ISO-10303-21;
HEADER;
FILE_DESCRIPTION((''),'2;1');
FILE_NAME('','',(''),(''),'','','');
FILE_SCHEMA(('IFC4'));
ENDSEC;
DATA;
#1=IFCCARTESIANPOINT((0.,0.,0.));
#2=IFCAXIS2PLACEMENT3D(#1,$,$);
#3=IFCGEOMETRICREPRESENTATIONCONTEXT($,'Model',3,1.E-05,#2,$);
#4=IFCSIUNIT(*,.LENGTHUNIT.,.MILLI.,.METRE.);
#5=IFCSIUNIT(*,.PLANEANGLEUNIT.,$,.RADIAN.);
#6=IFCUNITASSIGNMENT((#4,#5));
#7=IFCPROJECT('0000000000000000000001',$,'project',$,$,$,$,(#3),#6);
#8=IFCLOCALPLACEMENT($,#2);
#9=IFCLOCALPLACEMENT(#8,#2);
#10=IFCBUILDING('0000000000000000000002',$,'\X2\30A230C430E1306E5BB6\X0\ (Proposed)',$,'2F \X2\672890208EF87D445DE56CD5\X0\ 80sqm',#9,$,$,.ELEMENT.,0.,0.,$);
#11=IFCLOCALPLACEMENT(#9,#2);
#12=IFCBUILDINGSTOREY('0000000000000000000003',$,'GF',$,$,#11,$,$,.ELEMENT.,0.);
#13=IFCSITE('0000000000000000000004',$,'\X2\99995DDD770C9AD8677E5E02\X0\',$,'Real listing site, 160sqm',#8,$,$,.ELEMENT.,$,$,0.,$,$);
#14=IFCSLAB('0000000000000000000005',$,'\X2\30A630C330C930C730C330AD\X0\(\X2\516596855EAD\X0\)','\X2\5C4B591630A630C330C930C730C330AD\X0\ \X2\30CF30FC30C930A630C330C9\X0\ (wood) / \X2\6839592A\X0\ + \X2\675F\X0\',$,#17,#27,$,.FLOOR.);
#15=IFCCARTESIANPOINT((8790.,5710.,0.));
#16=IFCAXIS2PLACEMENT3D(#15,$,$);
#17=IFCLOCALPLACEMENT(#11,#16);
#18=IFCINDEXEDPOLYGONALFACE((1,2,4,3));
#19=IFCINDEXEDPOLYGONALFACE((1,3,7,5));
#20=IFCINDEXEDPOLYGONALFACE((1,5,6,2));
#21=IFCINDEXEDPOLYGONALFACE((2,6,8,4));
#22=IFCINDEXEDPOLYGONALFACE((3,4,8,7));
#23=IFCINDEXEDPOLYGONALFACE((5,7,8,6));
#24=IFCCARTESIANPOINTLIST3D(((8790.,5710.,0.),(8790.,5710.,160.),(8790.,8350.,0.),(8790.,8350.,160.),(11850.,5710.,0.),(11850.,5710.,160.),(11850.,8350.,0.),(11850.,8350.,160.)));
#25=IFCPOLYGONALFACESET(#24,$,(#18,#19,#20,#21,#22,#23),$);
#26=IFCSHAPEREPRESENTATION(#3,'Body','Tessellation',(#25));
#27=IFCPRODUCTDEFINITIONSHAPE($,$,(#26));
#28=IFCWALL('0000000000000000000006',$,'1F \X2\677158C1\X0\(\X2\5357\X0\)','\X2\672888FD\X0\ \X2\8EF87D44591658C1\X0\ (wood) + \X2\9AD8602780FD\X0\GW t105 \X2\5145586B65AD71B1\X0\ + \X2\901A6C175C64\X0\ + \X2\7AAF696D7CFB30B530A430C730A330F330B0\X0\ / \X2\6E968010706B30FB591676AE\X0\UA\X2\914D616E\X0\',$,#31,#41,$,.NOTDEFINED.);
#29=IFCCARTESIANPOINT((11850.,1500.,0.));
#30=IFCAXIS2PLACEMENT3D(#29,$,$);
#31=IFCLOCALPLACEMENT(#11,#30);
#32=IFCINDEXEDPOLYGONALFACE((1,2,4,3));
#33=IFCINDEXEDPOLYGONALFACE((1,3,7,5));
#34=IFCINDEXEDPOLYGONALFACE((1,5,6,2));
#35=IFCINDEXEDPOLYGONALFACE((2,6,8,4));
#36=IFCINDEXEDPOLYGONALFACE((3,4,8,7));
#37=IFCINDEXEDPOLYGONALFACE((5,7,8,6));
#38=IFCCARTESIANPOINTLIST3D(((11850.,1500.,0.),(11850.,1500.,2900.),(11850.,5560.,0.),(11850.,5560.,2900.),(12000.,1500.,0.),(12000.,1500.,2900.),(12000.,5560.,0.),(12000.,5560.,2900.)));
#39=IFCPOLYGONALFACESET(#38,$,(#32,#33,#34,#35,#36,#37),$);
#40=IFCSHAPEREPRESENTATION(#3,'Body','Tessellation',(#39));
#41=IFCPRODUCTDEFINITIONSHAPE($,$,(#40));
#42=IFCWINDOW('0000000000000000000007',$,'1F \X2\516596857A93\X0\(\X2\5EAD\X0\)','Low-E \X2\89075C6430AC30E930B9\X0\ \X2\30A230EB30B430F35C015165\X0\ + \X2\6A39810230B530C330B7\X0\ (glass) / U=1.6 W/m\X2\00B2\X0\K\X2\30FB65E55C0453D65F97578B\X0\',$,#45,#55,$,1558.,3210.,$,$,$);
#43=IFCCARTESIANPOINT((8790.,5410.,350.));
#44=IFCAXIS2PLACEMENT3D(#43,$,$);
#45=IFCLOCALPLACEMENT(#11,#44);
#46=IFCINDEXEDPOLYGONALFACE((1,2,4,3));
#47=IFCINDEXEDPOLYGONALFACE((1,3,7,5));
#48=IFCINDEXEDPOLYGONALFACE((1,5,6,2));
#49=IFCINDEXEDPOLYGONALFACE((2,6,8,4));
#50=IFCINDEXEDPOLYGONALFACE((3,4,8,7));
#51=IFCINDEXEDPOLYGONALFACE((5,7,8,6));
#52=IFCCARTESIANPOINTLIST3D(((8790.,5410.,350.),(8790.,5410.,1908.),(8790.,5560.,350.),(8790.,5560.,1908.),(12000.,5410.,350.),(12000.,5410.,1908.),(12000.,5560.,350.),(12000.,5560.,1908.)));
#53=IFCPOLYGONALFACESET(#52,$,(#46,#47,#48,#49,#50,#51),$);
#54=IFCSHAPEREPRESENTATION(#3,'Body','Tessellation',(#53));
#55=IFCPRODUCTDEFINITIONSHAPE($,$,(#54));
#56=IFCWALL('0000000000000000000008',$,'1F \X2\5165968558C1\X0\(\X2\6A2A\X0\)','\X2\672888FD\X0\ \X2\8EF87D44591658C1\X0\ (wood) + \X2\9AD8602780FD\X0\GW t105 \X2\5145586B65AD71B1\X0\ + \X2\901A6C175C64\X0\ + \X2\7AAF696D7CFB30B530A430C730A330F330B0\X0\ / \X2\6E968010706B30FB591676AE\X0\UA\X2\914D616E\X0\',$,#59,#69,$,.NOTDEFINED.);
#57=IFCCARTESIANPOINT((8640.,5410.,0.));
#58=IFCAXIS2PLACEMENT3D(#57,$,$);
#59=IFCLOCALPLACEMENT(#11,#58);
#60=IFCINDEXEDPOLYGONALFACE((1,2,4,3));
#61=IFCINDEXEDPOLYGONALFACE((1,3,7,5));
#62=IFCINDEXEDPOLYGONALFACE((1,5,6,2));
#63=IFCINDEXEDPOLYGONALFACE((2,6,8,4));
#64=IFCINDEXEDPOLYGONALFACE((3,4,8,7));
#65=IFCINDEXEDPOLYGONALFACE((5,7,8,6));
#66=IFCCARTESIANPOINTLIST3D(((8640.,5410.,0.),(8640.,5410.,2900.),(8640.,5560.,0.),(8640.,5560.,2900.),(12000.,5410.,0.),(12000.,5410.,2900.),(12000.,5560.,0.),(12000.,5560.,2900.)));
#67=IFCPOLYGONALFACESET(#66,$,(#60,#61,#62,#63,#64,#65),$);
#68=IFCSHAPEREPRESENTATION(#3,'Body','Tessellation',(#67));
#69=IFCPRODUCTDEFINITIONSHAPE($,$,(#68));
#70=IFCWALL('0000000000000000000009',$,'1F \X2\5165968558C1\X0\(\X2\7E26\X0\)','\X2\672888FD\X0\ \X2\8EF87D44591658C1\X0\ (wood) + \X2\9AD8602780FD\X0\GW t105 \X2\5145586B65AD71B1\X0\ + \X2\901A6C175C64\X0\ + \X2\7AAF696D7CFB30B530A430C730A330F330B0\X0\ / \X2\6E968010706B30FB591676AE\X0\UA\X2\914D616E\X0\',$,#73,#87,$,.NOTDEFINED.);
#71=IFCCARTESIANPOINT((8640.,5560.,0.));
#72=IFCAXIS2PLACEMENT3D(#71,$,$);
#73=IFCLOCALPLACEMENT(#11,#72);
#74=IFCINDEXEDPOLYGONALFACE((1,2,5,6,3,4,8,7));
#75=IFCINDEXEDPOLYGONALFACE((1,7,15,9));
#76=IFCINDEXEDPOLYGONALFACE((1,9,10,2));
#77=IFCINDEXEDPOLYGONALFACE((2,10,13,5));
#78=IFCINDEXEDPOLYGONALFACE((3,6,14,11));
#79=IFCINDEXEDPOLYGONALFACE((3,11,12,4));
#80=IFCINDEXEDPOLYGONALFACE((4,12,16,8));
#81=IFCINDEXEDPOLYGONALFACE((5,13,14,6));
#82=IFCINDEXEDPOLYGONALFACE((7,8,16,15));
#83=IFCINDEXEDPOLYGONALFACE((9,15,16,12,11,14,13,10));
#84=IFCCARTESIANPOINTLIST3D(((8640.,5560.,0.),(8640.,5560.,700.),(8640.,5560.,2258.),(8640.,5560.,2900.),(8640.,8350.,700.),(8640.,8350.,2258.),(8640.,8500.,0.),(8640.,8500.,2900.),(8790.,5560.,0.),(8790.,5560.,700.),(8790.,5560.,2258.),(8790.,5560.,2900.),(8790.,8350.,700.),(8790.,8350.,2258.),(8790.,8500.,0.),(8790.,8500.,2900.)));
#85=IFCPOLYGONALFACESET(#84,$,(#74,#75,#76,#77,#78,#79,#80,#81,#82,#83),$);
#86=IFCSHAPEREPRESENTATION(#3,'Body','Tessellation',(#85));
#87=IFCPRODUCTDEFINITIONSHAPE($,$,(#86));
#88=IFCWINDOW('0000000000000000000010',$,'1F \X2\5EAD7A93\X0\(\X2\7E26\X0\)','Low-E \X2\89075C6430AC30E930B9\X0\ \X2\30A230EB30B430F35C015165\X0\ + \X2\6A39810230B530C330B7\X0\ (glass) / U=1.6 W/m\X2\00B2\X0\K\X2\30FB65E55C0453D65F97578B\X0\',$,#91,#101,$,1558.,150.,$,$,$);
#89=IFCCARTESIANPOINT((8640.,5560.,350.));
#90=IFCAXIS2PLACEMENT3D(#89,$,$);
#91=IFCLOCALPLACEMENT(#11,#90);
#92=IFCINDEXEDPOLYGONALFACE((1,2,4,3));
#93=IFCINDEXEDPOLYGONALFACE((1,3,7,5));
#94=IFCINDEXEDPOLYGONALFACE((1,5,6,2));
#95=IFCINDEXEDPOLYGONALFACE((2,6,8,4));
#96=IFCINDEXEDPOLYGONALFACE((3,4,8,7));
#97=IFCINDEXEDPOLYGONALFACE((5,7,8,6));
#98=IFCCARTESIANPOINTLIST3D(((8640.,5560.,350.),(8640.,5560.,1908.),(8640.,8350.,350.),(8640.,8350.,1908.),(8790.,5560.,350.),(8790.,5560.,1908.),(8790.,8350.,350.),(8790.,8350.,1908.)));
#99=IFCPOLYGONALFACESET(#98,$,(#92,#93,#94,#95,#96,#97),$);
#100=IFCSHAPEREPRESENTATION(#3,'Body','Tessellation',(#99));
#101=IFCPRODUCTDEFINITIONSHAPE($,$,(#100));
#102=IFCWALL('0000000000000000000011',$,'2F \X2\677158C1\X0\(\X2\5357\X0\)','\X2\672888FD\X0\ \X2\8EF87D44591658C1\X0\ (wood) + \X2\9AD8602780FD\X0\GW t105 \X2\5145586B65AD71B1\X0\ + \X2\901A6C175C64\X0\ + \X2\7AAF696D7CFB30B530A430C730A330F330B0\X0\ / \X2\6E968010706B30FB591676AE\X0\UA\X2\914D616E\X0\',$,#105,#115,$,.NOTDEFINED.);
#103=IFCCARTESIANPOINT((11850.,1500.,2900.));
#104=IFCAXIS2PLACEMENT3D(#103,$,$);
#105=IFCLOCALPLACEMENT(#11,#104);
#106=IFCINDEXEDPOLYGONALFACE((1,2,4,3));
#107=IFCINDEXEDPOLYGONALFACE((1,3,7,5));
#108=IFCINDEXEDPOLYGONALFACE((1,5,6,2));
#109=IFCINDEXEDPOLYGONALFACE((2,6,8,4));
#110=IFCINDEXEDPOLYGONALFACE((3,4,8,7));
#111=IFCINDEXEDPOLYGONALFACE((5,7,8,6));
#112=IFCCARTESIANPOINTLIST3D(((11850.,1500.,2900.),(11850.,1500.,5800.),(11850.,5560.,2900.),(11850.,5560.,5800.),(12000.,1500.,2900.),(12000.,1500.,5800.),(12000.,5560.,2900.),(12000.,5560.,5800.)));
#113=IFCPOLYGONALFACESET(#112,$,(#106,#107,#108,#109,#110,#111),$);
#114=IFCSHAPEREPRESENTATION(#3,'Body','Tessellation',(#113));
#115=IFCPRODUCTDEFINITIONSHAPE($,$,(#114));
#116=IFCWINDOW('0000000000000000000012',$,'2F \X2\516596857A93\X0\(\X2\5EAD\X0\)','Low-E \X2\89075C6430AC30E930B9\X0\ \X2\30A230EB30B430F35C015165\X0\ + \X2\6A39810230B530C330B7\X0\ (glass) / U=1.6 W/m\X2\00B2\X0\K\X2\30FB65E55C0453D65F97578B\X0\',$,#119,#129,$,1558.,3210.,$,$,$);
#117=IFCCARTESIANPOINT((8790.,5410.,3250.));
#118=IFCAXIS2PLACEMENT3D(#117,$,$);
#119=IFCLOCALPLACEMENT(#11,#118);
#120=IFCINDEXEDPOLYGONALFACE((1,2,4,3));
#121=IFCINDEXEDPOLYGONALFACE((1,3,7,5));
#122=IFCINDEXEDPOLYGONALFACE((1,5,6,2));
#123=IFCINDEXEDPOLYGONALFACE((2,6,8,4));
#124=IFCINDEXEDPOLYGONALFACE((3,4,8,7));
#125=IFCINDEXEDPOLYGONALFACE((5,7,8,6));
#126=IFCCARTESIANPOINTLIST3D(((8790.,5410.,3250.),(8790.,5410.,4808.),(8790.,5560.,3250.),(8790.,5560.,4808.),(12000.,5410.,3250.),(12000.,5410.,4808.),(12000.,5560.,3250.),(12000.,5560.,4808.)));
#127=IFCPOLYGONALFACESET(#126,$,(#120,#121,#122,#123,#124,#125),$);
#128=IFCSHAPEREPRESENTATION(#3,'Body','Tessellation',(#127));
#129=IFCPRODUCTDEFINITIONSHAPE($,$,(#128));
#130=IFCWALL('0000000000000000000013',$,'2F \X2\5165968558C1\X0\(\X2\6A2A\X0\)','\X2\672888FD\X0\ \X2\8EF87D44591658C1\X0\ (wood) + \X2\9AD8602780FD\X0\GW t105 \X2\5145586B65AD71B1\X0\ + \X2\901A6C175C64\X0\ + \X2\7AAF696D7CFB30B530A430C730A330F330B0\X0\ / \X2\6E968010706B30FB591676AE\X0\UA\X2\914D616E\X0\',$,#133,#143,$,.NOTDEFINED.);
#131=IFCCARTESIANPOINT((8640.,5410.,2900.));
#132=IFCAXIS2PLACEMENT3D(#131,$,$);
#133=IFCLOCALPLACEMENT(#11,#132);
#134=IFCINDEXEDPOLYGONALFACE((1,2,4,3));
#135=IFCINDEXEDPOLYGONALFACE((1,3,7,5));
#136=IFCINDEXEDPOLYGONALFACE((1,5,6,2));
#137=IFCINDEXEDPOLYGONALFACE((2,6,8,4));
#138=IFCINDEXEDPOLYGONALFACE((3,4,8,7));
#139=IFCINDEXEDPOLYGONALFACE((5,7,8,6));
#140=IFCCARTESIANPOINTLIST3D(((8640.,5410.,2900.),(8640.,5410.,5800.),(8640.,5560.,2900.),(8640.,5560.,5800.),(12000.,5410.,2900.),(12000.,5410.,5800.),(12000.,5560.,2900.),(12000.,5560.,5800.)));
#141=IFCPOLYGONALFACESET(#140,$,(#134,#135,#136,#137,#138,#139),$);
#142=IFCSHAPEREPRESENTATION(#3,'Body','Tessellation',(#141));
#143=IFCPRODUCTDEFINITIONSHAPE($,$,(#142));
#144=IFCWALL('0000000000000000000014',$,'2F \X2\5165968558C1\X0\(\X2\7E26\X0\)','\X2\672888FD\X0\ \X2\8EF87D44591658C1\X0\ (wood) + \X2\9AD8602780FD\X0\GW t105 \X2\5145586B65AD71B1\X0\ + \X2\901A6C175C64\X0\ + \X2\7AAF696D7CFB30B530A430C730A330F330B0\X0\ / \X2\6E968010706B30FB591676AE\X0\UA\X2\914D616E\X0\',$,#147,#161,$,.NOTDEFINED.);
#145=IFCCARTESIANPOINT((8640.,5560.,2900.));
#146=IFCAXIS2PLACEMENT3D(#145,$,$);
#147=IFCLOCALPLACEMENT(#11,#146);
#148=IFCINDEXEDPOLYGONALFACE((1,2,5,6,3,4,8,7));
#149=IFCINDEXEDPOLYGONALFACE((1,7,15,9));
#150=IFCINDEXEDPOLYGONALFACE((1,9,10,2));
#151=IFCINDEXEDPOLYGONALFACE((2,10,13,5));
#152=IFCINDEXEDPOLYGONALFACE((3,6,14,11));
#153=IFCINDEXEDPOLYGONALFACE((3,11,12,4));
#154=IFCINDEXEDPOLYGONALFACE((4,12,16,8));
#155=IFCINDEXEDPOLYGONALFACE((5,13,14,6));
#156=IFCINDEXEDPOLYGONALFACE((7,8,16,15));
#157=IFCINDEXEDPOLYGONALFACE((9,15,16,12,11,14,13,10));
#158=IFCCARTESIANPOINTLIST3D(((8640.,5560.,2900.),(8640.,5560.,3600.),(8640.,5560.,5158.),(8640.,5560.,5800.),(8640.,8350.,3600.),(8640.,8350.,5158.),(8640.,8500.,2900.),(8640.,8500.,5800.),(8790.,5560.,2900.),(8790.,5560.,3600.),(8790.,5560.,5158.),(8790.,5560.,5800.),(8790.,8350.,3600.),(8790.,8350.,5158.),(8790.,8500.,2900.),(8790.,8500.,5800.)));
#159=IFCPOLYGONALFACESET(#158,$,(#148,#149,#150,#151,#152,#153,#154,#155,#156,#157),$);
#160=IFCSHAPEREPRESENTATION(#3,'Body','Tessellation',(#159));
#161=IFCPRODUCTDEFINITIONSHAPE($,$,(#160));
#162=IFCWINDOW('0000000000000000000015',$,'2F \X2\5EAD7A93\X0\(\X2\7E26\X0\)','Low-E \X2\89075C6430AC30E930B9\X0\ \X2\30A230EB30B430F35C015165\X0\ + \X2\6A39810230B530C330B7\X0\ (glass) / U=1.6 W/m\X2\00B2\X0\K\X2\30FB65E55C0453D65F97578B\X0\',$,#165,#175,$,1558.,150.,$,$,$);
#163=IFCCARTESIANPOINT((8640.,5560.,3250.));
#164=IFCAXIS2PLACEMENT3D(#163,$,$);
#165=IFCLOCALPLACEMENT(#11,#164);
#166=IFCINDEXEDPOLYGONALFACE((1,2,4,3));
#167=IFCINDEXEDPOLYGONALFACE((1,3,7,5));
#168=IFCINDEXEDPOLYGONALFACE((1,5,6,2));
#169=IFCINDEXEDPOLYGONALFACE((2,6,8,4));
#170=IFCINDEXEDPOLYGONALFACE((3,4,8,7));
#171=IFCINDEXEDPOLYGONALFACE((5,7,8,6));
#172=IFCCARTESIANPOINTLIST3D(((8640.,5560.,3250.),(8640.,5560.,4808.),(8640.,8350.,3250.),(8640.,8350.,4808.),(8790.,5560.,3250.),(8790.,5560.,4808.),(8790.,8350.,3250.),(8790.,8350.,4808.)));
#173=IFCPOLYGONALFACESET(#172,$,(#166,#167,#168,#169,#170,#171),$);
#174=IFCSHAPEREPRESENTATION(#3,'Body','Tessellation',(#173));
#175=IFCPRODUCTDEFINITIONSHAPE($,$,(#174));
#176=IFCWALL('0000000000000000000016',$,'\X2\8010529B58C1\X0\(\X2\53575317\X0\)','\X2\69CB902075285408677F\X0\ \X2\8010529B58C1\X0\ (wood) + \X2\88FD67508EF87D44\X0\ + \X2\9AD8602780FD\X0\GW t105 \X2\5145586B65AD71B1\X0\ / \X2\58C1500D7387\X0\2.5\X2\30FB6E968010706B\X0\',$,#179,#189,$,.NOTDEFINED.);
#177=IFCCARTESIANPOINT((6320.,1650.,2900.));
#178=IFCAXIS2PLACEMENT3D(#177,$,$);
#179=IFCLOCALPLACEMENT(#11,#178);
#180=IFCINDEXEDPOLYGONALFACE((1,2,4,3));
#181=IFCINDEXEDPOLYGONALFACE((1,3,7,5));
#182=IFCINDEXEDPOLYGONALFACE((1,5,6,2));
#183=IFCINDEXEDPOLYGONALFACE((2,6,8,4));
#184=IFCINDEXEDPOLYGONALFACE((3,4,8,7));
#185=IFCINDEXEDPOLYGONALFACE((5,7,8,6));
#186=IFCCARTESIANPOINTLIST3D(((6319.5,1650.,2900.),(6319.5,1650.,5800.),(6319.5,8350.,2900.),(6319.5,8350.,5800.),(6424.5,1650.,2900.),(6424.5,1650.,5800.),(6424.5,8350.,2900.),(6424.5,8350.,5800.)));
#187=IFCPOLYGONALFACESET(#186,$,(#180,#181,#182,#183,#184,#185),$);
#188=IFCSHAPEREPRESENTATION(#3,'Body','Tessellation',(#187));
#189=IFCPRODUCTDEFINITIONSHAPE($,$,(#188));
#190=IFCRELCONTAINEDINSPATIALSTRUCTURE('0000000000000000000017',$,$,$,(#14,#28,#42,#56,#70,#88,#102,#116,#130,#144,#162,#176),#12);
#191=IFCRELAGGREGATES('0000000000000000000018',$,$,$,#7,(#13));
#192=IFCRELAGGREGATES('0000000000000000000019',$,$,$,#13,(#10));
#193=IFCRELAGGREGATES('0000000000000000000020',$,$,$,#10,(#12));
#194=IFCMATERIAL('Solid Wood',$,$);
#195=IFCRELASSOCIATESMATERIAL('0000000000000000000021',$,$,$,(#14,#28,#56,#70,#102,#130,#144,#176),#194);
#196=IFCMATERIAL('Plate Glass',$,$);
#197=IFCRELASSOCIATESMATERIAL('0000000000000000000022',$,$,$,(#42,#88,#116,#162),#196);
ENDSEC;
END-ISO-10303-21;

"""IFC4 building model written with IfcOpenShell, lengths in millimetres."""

from ifc_helpers import new_model, si_unit, frame, frame_2d, origin, place, context, project, spatial, rectangle, extrude, material, element, fill, save


model = new_model("IFC4")

# Units and contexts
model_context = context("Model", 3, precision=1e-05, world=origin())
ifc_project = project(units=[si_unit("LENGTHUNIT", "METRE", prefix="MILLI"), si_unit("PLANEANGLEUNIT", "RADIAN")], contexts=[model_context])

# Site, building, storey
site_placement = place(None, origin())
site = spatial("IfcSite", under=ifc_project, at=site_placement, Name="香川県高松市", ObjectType="Real listing site, 160sqm", CompositionType="ELEMENT", RefElevation=0.0)
building_placement = place(site_placement, origin())
building = spatial("IfcBuilding", under=site, at=building_placement, Name="アツメの家 (Proposed)", ObjectType="2F 木造軸組工法 80sqm", CompositionType="ELEMENT", ElevationOfRefHeight=0.0, ElevationOfTerrain=0.0)
storey_placement = place(building_placement, origin())
storey = spatial("IfcBuildingStorey", under=building, at=storey_placement, Name="GF", CompositionType="ELEMENT", Elevation=0.0)

# Slab
ifc_material_1 = material(Name="Solid Wood")
slab_placement = place(storey_placement, frame((8790.0, 5710.0, 0.0)))
element("IfcSlab", 1, at=slab_placement, inside=storey, material=ifc_material_1, Name="ウッドデッキ(入隅庭)", Description="屋外ウッドデッキ ハードウッド (wood) / 根太 + 束", PredefinedType="FLOOR", context=model_context, shape_type="SweptSolid", body=[
    extrude(rectangle(XDim=3060.0, YDim=2640.0, at=frame_2d((1530.0, 1320.0))), frame((8790.0, 5710.0, 0.0)), (0.0, 0.0, 1.0), 160.0),
])

# Wall, opening, window
wall_1_placement = place(storey_placement, frame((11850.0, 1500.0, 0.0)))
wall_1 = element("IfcWall", 2, at=wall_1_placement, inside=storey, material=ifc_material_1, Name="1F 東壁(南)", Description="木製 軸組外壁 (wood) + 高性能GW t105 充填断熱 + 通気層 + 窯業系サイディング / 準耐火・外皮UA配慮", PredefinedType="NOTDEFINED", context=model_context, shape_type="SweptSolid", body=[
    extrude(rectangle(XDim=150.0, YDim=4060.0, at=frame_2d((75.0, 2030.0))), frame((11850.0, 1500.0, 0.0)), (0.0, 0.0, 1.0), 2900.0),
])
opening_1_placement = place(storey_placement, frame((8790.0, 5410.0, 350.0)))
opening_1 = element("IfcOpeningElement", 3, at=opening_1_placement, cuts=wall_1, PredefinedType="NOTDEFINED", context=model_context, shape_type="SweptSolid", body=[
    extrude(rectangle(XDim=3210.0, YDim=150.0, at=frame_2d((1605.0, 75.0))), frame((8790.0, 5410.0, 350.0)), (0.0, 0.0, 1.0), 1558.0),
])
ifc_material_2 = material(Name="Plate Glass")
window_1_placement = place(storey_placement, frame((8790.0, 5410.0, 350.0)))
window_1 = element("IfcWindow", 4, at=window_1_placement, inside=storey, material=ifc_material_2, Name="1F 入隅窓(庭)", Description="Low-E 複層ガラス アルゴン封入 + 樹脂サッシ (glass) / U=1.6 W/m²K・日射取得型", OverallHeight=1558.0, OverallWidth=3210.0, context=model_context, shape_type="SweptSolid", body=[
    extrude(rectangle(XDim=3210.0, YDim=150.0, at=frame_2d((1605.0, 75.0))), frame((8790.0, 5410.0, 350.0)), (0.0, 0.0, 1.0), 1558.0),
])
fill(opening_1, window_1)

# Wall
wall_2_placement = place(storey_placement, frame((8640.0, 5410.0, 0.0)))
element("IfcWall", 5, at=wall_2_placement, inside=storey, material=ifc_material_1, Name="1F 入隅壁(横)", Description="木製 軸組外壁 (wood) + 高性能GW t105 充填断熱 + 通気層 + 窯業系サイディング / 準耐火・外皮UA配慮", PredefinedType="NOTDEFINED", context=model_context, shape_type="SweptSolid", body=[
    extrude(rectangle(XDim=3360.0, YDim=150.0, at=frame_2d((1680.0, 75.0))), frame((8640.0, 5410.0, 0.0)), (0.0, 0.0, 1.0), 2900.0),
])

# Wall, opening, window
wall_3_placement = place(storey_placement, frame((8640.0, 5560.0, 0.0)))
wall_3 = element("IfcWall", 6, at=wall_3_placement, inside=storey, material=ifc_material_1, Name="1F 入隅壁(縦)", Description="木製 軸組外壁 (wood) + 高性能GW t105 充填断熱 + 通気層 + 窯業系サイディング / 準耐火・外皮UA配慮", PredefinedType="NOTDEFINED", context=model_context, shape_type="SweptSolid", body=[
    extrude(rectangle(XDim=150.0, YDim=2940.0, at=frame_2d((75.0, 1470.0))), frame((8640.0, 5560.0, 0.0)), (0.0, 0.0, 1.0), 2900.0),
])
opening_2_placement = place(storey_placement, frame((8640.0, 5560.0, 350.0)))
opening_2 = element("IfcOpeningElement", 7, at=opening_2_placement, cuts=wall_3, PredefinedType="NOTDEFINED", context=model_context, shape_type="SweptSolid", body=[
    extrude(rectangle(XDim=150.0, YDim=2790.0, at=frame_2d((75.0, 1395.0))), frame((8640.0, 5560.0, 350.0)), (0.0, 0.0, 1.0), 1558.0),
])
window_2_placement = place(storey_placement, frame((8640.0, 5560.0, 350.0)))
window_2 = element("IfcWindow", 8, at=window_2_placement, inside=storey, material=ifc_material_2, Name="1F 庭窓(縦)", Description="Low-E 複層ガラス アルゴン封入 + 樹脂サッシ (glass) / U=1.6 W/m²K・日射取得型", OverallHeight=1558.0, OverallWidth=150.0, context=model_context, shape_type="SweptSolid", body=[
    extrude(rectangle(XDim=150.0, YDim=2790.0, at=frame_2d((75.0, 1395.0))), frame((8640.0, 5560.0, 350.0)), (0.0, 0.0, 1.0), 1558.0),
])
fill(opening_2, window_2)

# Wall, opening, window
wall_4_placement = place(storey_placement, frame((11850.0, 1500.0, 2900.0)))
wall_4 = element("IfcWall", 9, at=wall_4_placement, inside=storey, material=ifc_material_1, Name="2F 東壁(南)", Description="木製 軸組外壁 (wood) + 高性能GW t105 充填断熱 + 通気層 + 窯業系サイディング / 準耐火・外皮UA配慮", PredefinedType="NOTDEFINED", context=model_context, shape_type="SweptSolid", body=[
    extrude(rectangle(XDim=150.0, YDim=4060.0, at=frame_2d((75.0, 2030.0))), frame((11850.0, 1500.0, 2900.0)), (0.0, 0.0, 1.0), 2900.0),
])
opening_3_placement = place(storey_placement, frame((8790.0, 5410.0, 3250.0)))
opening_3 = element("IfcOpeningElement", 10, at=opening_3_placement, cuts=wall_4, PredefinedType="NOTDEFINED", context=model_context, shape_type="SweptSolid", body=[
    extrude(rectangle(XDim=3210.0, YDim=150.0, at=frame_2d((1605.0, 75.0))), frame((8790.0, 5410.0, 3250.0)), (0.0, 0.0, 1.0), 1558.0),
])
window_3_placement = place(storey_placement, frame((8790.0, 5410.0, 3250.0)))
window_3 = element("IfcWindow", 11, at=window_3_placement, inside=storey, material=ifc_material_2, Name="2F 入隅窓(庭)", Description="Low-E 複層ガラス アルゴン封入 + 樹脂サッシ (glass) / U=1.6 W/m²K・日射取得型", OverallHeight=1558.0, OverallWidth=3210.0, context=model_context, shape_type="SweptSolid", body=[
    extrude(rectangle(XDim=3210.0, YDim=150.0, at=frame_2d((1605.0, 75.0))), frame((8790.0, 5410.0, 3250.0)), (0.0, 0.0, 1.0), 1558.0),
])
fill(opening_3, window_3)

# Wall
wall_5_placement = place(storey_placement, frame((8640.0, 5410.0, 2900.0)))
element("IfcWall", 12, at=wall_5_placement, inside=storey, material=ifc_material_1, Name="2F 入隅壁(横)", Description="木製 軸組外壁 (wood) + 高性能GW t105 充填断熱 + 通気層 + 窯業系サイディング / 準耐火・外皮UA配慮", PredefinedType="NOTDEFINED", context=model_context, shape_type="SweptSolid", body=[
    extrude(rectangle(XDim=3360.0, YDim=150.0, at=frame_2d((1680.0, 75.0))), frame((8640.0, 5410.0, 2900.0)), (0.0, 0.0, 1.0), 2900.0),
])

# Wall, opening, window
wall_6_placement = place(storey_placement, frame((8640.0, 5560.0, 2900.0)))
wall_6 = element("IfcWall", 13, at=wall_6_placement, inside=storey, material=ifc_material_1, Name="2F 入隅壁(縦)", Description="木製 軸組外壁 (wood) + 高性能GW t105 充填断熱 + 通気層 + 窯業系サイディング / 準耐火・外皮UA配慮", PredefinedType="NOTDEFINED", context=model_context, shape_type="SweptSolid", body=[
    extrude(rectangle(XDim=150.0, YDim=2940.0, at=frame_2d((75.0, 1470.0))), frame((8640.0, 5560.0, 2900.0)), (0.0, 0.0, 1.0), 2900.0),
])
opening_4_placement = place(storey_placement, frame((8640.0, 5560.0, 3250.0)))
opening_4 = element("IfcOpeningElement", 14, at=opening_4_placement, cuts=wall_6, PredefinedType="NOTDEFINED", context=model_context, shape_type="SweptSolid", body=[
    extrude(rectangle(XDim=150.0, YDim=2790.0, at=frame_2d((75.0, 1395.0))), frame((8640.0, 5560.0, 3250.0)), (0.0, 0.0, 1.0), 1558.0),
])
window_4_placement = place(storey_placement, frame((8640.0, 5560.0, 3250.0)))
window_4 = element("IfcWindow", 15, at=window_4_placement, inside=storey, material=ifc_material_2, Name="2F 庭窓(縦)", Description="Low-E 複層ガラス アルゴン封入 + 樹脂サッシ (glass) / U=1.6 W/m²K・日射取得型", OverallHeight=1558.0, OverallWidth=150.0, context=model_context, shape_type="SweptSolid", body=[
    extrude(rectangle(XDim=150.0, YDim=2790.0, at=frame_2d((75.0, 1395.0))), frame((8640.0, 5560.0, 3250.0)), (0.0, 0.0, 1.0), 1558.0),
])
fill(opening_4, window_4)

# Wall
wall_7_placement = place(storey_placement, frame((6320.0, 1650.0, 2900.0)))
element("IfcWall", 16, at=wall_7_placement, inside=storey, material=ifc_material_1, Name="耐力壁(南北)", Description="構造用合板 耐力壁 (wood) + 製材軸組 + 高性能GW t105 充填断熱 / 壁倍率2.5・準耐火", PredefinedType="NOTDEFINED", context=model_context, shape_type="SweptSolid", body=[
    extrude(rectangle(XDim=105.0, YDim=6700.0, at=frame_2d((52.0, 3350.0))), frame((6320.0, 1650.0, 2900.0)), (0.0, 0.0, 1.0), 2900.0),
])

save(model, "model.ifc")
